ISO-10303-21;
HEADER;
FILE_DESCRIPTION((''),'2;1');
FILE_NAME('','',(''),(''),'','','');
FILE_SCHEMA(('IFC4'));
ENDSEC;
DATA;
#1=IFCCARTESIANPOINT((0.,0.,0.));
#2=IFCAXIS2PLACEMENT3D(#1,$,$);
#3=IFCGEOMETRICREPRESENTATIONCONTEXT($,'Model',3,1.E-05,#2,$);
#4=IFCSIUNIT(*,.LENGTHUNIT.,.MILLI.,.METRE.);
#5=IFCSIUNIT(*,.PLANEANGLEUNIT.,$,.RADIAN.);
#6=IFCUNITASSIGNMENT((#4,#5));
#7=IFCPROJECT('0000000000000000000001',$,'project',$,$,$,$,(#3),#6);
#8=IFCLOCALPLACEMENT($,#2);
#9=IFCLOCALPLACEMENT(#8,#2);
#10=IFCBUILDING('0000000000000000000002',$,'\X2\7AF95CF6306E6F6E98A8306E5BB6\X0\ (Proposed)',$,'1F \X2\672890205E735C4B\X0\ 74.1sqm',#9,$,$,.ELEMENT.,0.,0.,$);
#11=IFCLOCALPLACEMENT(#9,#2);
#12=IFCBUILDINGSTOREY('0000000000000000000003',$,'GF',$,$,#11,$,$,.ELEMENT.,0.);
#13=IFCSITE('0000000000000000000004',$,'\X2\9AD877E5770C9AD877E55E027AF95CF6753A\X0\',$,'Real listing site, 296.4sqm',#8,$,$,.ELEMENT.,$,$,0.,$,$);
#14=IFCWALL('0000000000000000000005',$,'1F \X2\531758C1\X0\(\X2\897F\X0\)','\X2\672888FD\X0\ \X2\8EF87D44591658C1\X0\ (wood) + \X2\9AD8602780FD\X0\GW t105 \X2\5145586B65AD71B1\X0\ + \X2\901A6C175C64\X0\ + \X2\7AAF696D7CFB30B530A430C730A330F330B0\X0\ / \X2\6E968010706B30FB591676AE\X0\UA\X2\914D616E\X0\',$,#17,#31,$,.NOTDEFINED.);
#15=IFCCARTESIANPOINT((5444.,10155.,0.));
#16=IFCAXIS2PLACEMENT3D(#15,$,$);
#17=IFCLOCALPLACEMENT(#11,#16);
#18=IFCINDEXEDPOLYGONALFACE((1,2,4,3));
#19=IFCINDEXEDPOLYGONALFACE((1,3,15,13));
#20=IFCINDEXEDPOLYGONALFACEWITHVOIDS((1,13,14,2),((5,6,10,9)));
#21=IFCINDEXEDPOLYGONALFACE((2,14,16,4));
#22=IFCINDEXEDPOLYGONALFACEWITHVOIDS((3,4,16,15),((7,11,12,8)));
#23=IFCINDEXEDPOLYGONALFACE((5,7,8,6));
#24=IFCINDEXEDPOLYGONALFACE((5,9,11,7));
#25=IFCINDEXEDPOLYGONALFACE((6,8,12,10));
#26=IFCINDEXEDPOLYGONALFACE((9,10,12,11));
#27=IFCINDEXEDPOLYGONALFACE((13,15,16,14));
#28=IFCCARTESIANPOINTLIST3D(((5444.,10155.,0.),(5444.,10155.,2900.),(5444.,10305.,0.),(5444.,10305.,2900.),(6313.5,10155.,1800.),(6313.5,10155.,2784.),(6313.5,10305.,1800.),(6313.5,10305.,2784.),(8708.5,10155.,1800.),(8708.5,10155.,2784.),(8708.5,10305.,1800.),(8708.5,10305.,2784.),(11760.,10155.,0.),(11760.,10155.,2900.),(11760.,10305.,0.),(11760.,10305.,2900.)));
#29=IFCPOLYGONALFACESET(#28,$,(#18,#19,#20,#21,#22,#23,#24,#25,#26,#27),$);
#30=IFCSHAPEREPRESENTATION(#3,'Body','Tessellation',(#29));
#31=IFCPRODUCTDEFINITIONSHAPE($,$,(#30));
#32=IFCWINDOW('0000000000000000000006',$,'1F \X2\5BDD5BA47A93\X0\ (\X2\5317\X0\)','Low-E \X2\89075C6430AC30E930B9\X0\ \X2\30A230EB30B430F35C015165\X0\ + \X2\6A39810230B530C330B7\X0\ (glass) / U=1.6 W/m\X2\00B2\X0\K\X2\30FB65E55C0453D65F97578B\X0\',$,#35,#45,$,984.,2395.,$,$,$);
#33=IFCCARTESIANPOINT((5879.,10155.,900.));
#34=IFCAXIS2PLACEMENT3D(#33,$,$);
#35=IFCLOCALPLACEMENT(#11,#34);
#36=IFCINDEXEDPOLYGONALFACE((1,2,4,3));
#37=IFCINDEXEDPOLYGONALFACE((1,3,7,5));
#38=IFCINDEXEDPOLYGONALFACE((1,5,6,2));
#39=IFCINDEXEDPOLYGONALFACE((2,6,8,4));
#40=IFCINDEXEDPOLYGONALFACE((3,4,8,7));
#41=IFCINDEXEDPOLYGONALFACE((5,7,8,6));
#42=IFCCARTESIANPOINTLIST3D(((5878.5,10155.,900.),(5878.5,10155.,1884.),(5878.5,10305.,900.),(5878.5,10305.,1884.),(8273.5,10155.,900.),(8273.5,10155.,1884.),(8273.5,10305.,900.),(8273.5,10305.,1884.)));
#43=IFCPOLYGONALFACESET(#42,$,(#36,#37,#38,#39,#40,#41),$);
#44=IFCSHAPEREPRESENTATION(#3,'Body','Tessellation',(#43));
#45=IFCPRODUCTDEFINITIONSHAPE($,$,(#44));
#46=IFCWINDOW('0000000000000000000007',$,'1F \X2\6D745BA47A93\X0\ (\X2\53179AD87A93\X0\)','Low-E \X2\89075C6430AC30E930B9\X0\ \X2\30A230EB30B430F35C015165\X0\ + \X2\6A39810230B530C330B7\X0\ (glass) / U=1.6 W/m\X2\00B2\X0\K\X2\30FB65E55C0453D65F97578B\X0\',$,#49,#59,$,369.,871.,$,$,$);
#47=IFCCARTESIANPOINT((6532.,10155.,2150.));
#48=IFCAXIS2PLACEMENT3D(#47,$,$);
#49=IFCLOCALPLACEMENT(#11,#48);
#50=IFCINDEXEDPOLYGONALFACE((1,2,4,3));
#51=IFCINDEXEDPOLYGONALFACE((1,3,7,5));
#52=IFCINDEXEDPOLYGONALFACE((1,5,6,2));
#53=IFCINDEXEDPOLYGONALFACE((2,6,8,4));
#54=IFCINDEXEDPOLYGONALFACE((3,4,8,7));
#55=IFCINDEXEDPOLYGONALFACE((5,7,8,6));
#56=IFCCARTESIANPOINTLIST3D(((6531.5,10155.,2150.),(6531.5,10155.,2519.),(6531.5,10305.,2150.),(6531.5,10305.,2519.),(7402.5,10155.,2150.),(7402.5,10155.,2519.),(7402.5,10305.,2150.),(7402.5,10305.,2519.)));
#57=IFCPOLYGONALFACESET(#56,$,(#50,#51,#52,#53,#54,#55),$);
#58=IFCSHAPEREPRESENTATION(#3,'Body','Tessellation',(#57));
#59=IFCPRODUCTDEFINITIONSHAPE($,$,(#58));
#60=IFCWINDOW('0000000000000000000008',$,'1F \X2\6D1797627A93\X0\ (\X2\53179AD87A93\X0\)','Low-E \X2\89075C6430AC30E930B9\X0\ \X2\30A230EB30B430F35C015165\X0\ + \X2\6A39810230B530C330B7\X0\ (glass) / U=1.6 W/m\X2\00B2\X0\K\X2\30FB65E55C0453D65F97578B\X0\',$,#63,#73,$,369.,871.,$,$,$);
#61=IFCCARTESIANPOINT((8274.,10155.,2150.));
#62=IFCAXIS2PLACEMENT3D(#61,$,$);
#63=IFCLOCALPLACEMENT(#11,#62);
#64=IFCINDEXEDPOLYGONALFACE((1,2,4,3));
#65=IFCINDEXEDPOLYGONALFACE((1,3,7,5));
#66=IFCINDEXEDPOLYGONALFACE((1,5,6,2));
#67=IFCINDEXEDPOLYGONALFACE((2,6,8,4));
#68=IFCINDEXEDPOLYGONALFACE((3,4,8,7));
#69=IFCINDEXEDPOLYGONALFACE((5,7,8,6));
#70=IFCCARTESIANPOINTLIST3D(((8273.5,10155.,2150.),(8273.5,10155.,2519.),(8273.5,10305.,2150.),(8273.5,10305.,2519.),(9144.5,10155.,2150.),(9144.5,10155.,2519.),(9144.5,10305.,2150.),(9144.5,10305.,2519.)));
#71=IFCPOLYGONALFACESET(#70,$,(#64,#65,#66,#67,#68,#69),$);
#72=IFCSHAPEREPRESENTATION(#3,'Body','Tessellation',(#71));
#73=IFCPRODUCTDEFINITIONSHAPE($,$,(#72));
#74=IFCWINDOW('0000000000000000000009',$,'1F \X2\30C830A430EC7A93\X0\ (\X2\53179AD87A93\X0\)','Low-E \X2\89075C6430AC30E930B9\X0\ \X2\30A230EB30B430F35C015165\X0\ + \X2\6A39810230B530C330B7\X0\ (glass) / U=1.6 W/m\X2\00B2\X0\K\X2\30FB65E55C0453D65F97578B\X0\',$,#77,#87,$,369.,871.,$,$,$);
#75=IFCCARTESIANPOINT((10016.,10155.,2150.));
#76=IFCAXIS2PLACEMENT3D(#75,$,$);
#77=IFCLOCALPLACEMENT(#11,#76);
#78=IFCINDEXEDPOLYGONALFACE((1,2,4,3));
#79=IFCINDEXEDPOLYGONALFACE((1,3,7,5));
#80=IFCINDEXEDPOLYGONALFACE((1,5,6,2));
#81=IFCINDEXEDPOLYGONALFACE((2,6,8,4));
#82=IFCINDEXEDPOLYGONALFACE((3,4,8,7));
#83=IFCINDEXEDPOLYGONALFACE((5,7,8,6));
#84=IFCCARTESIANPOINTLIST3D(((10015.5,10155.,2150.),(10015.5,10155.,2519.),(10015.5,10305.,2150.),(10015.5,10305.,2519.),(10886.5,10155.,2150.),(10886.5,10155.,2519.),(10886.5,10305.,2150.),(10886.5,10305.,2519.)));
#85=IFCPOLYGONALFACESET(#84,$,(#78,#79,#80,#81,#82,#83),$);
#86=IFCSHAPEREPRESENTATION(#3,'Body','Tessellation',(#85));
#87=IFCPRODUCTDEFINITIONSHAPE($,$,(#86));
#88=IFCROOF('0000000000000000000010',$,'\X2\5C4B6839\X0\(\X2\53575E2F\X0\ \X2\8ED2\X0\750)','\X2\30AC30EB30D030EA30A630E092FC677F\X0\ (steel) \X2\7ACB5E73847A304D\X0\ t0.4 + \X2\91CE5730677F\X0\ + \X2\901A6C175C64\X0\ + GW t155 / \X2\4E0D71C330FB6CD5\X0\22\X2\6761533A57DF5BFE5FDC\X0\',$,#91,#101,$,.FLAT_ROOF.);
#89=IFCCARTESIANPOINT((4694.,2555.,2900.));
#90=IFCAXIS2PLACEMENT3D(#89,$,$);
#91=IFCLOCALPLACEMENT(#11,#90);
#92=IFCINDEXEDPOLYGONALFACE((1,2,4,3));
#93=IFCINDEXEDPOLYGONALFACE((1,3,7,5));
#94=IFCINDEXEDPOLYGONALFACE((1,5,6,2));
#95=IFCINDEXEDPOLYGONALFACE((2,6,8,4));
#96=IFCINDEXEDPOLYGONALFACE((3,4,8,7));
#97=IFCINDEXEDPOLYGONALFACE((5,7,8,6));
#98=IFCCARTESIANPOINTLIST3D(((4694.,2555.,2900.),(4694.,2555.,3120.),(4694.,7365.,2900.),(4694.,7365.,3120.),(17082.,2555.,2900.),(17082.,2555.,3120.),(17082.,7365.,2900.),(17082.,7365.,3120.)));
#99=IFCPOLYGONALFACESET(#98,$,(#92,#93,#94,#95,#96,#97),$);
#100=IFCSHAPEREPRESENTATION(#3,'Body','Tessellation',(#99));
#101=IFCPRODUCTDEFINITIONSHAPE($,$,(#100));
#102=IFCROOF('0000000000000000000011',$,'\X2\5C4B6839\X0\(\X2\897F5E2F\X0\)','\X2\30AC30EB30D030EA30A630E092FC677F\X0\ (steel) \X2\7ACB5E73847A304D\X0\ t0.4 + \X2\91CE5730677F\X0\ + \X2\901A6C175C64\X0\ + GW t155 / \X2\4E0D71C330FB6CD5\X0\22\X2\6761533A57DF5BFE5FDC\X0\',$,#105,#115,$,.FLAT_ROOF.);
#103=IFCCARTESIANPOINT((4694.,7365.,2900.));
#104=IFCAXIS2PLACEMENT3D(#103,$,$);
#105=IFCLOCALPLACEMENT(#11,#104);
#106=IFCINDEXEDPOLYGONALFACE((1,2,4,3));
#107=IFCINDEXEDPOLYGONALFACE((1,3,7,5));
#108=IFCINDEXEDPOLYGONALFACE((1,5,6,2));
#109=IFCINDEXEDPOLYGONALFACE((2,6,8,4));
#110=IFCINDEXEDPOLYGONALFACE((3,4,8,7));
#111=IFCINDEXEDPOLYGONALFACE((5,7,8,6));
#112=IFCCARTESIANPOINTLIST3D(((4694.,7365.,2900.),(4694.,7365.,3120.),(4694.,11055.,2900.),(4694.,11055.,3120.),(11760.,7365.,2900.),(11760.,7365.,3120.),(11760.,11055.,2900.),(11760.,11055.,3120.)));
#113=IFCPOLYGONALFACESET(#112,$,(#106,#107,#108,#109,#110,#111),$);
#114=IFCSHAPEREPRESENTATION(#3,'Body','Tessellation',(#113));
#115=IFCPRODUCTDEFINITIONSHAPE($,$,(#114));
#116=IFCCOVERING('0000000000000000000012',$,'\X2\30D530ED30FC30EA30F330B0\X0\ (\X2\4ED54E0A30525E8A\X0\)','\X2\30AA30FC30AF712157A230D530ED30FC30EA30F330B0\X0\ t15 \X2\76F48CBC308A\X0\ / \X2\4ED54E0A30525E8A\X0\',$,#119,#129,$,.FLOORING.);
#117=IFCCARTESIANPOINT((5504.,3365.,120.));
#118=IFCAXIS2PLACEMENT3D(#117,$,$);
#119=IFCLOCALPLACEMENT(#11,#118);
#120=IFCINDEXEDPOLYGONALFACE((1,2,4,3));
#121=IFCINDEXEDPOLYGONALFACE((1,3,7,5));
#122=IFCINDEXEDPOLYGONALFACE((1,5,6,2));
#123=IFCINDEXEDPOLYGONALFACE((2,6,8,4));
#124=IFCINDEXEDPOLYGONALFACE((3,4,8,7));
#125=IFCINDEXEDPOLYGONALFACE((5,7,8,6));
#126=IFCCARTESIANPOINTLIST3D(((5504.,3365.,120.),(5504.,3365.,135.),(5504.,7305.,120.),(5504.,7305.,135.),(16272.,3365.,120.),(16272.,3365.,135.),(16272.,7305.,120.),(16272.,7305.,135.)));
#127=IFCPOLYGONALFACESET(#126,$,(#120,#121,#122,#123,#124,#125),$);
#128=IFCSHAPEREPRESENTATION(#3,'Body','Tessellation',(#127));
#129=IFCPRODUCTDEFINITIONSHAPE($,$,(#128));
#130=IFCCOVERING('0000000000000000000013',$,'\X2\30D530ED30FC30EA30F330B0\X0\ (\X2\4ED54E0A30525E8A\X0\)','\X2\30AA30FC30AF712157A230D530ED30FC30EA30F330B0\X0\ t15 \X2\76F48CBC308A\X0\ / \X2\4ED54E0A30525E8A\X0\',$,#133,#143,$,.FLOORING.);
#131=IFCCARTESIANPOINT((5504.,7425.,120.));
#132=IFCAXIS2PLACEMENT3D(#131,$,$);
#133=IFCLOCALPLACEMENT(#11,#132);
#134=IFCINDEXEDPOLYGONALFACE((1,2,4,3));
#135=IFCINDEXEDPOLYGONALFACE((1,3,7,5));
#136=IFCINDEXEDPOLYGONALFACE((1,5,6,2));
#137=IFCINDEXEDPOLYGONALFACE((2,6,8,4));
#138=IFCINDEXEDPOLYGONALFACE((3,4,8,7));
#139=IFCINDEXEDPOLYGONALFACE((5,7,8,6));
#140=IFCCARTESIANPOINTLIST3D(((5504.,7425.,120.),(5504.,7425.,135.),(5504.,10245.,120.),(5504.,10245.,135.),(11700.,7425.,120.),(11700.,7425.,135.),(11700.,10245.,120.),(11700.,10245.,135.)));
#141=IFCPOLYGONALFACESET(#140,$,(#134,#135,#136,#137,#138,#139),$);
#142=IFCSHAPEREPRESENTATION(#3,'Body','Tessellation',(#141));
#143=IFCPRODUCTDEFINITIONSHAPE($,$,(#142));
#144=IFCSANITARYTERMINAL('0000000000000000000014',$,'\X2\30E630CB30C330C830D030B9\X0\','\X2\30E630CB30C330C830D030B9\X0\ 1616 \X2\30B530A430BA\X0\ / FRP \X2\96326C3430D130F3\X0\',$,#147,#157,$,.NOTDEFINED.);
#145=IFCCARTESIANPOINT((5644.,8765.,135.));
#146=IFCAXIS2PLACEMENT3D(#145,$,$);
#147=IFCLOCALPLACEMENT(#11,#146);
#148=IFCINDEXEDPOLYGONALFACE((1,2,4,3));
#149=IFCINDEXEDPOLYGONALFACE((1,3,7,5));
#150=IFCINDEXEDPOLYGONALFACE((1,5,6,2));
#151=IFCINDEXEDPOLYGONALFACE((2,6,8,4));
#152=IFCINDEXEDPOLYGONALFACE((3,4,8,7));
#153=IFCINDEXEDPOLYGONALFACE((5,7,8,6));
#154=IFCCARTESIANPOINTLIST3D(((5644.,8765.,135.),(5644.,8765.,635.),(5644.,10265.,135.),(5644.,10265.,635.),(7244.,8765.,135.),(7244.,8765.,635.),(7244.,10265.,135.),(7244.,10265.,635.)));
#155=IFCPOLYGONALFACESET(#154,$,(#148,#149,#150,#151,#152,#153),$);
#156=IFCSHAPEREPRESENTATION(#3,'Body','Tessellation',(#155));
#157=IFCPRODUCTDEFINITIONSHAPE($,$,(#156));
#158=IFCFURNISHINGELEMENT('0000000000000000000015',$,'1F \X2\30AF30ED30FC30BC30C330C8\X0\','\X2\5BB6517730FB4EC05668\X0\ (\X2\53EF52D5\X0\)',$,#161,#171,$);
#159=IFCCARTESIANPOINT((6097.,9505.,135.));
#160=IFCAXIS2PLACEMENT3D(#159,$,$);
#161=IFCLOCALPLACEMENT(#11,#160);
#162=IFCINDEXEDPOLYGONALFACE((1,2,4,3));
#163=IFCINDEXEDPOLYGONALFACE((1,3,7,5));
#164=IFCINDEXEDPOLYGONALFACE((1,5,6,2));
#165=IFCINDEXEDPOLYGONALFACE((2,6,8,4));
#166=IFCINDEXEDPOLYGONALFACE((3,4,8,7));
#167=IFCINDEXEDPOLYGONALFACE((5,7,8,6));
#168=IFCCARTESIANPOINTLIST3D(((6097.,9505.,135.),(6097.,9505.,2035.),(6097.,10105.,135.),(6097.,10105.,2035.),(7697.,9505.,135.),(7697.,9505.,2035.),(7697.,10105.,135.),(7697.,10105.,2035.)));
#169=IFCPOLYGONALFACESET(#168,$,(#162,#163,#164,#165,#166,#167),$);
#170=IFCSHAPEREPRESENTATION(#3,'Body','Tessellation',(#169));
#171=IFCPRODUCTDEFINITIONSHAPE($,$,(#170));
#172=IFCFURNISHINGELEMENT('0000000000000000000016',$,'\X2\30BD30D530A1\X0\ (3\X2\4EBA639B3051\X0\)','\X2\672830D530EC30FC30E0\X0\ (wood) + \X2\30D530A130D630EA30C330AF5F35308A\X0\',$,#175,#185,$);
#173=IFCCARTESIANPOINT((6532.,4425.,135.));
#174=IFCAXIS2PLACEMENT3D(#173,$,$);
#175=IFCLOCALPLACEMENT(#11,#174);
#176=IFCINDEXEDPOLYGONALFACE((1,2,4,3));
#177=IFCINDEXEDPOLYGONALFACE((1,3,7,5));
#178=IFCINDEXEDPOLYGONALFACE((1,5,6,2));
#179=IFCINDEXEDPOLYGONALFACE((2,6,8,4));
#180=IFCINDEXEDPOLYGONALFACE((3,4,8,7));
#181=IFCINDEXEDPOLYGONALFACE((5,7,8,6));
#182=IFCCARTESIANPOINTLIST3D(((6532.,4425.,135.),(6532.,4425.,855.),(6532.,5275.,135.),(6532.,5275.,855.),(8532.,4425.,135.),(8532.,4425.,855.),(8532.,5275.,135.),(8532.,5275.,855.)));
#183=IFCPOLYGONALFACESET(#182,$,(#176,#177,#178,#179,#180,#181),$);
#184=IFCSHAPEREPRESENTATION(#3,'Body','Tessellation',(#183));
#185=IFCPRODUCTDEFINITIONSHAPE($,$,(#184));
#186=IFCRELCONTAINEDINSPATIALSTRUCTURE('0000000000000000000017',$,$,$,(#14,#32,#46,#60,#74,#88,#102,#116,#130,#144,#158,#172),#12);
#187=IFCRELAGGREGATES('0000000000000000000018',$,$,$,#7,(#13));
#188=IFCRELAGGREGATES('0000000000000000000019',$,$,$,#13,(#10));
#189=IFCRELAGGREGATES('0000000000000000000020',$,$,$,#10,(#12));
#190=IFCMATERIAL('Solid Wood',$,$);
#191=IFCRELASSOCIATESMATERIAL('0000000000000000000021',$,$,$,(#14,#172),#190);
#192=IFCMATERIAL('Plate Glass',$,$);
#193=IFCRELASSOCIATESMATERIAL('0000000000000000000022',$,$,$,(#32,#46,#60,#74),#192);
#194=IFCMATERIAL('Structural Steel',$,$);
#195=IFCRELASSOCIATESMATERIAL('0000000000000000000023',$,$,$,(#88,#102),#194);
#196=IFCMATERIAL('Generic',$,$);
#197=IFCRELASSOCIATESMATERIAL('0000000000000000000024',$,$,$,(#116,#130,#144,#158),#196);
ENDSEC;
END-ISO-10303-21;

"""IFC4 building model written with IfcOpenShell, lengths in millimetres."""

from ifc_helpers import new_model, si_unit, frame, frame_2d, origin, place, context, project, spatial, rectangle, extrude, material, element, fill, save


model = new_model("IFC4")

# Units and contexts
model_context = context("Model", 3, precision=1e-05, world=origin())
ifc_project = project(units=[si_unit("LENGTHUNIT", "METRE", prefix="MILLI"), si_unit("PLANEANGLEUNIT", "RADIAN")], contexts=[model_context])

# Site, building, storey
site_placement = place(None, origin())
site = spatial("IfcSite", under=ifc_project, at=site_placement, Name="高知県高知市竹島町", ObjectType="Real listing site, 296.4sqm", CompositionType="ELEMENT", RefElevation=0.0)
building_placement = place(site_placement, origin())
building = spatial("IfcBuilding", under=site, at=building_placement, Name="竹島の潮風の家 (Proposed)", ObjectType="1F 木造平屋 74.1sqm", CompositionType="ELEMENT", ElevationOfRefHeight=0.0, ElevationOfTerrain=0.0)
storey_placement = place(building_placement, origin())
storey = spatial("IfcBuildingStorey", under=building, at=storey_placement, Name="GF", CompositionType="ELEMENT", Elevation=0.0)

# Shared definitions
ifc_material_1 = material(Name="Solid Wood")

# Shared definitions
ifc_material_2 = material(Name="Plate Glass")

# Wall, openings, windows
wall_1_placement = place(storey_placement, frame((5444.0, 10155.0, 0.0)))
wall_1 = element("IfcWall", 1, at=wall_1_placement, inside=storey, material=ifc_material_1, Name="1F 北壁(西)", Description="木製 軸組外壁 (wood) + 高性能GW t105 充填断熱 + 通気層 + 窯業系サイディング / 準耐火・外皮UA配慮", PredefinedType="NOTDEFINED", context=model_context, shape_type="SweptSolid", body=[
    extrude(rectangle(XDim=6316.0, YDim=150.0, at=frame_2d((3158.0, 75.0))), frame((5444.0, 10155.0, 0.0)), (0.0, 0.0, 1.0), 2900.0),
])
opening_1_placement = place(storey_placement, frame((5879.0, 10155.0, 900.0)))
opening_1 = element("IfcOpeningElement", 2, at=opening_1_placement, cuts=wall_1, PredefinedType="NOTDEFINED", context=model_context, shape_type="SweptSolid", body=[
    extrude(rectangle(XDim=2395.0, YDim=150.0, at=frame_2d((1197.0, 75.0))), frame((5879.0, 10155.0, 900.0)), (0.0, 0.0, 1.0), 984.0),
])
opening_2_placement = place(storey_placement, frame((6532.0, 10155.0, 2150.0)))
opening_2 = element("IfcOpeningElement", 3, at=opening_2_placement, cuts=wall_1, PredefinedType="NOTDEFINED", context=model_context, shape_type="SweptSolid", body=[
    extrude(rectangle(XDim=871.0, YDim=150.0, at=frame_2d((435.0, 75.0))), frame((6532.0, 10155.0, 2150.0)), (0.0, 0.0, 1.0), 369.0),
])
opening_3_placement = place(storey_placement, frame((8274.0, 10155.0, 2150.0)))
opening_3 = element("IfcOpeningElement", 4, at=opening_3_placement, cuts=wall_1, PredefinedType="NOTDEFINED", context=model_context, shape_type="SweptSolid", body=[
    extrude(rectangle(XDim=871.0, YDim=150.0, at=frame_2d((435.0, 75.0))), frame((8274.0, 10155.0, 2150.0)), (0.0, 0.0, 1.0), 369.0),
])
opening_4_placement = place(storey_placement, frame((10016.0, 10155.0, 2150.0)))
opening_4 = element("IfcOpeningElement", 5, at=opening_4_placement, cuts=wall_1, PredefinedType="NOTDEFINED", context=model_context, shape_type="SweptSolid", body=[
    extrude(rectangle(XDim=871.0, YDim=150.0, at=frame_2d((435.0, 75.0))), frame((10016.0, 10155.0, 2150.0)), (0.0, 0.0, 1.0), 369.0),
])
window_1_placement = place(storey_placement, frame((5879.0, 10155.0, 900.0)))
window_1 = element("IfcWindow", 6, at=window_1_placement, inside=storey, material=ifc_material_2, Name="1F 寝室窓 (北)", Description="Low-E 複層ガラス アルゴン封入 + 樹脂サッシ (glass) / U=1.6 W/m²K・日射取得型", OverallHeight=984.0, OverallWidth=2395.0, context=model_context, shape_type="SweptSolid", body=[
    extrude(rectangle(XDim=2395.0, YDim=150.0, at=frame_2d((1197.0, 75.0))), frame((5879.0, 10155.0, 900.0)), (0.0, 0.0, 1.0), 984.0),
])
fill(opening_1, window_1)
window_2_placement = place(storey_placement, frame((6532.0, 10155.0, 2150.0)))
window_2 = element("IfcWindow", 7, at=window_2_placement, inside=storey, material=ifc_material_2, Name="1F 浴室窓 (北高窓)", Description="Low-E 複層ガラス アルゴン封入 + 樹脂サッシ (glass) / U=1.6 W/m²K・日射取得型", OverallHeight=369.0, OverallWidth=871.0, context=model_context, shape_type="SweptSolid", body=[
    extrude(rectangle(XDim=871.0, YDim=150.0, at=frame_2d((435.0, 75.0))), frame((6532.0, 10155.0, 2150.0)), (0.0, 0.0, 1.0), 369.0),
])
fill(opening_2, window_2)
window_3_placement = place(storey_placement, frame((8274.0, 10155.0, 2150.0)))
window_3 = element("IfcWindow", 8, at=window_3_placement, inside=storey, material=ifc_material_2, Name="1F 洗面窓 (北高窓)", Description="Low-E 複層ガラス アルゴン封入 + 樹脂サッシ (glass) / U=1.6 W/m²K・日射取得型", OverallHeight=369.0, OverallWidth=871.0, context=model_context, shape_type="SweptSolid", body=[
    extrude(rectangle(XDim=871.0, YDim=150.0, at=frame_2d((435.0, 75.0))), frame((8274.0, 10155.0, 2150.0)), (0.0, 0.0, 1.0), 369.0),
])
fill(opening_3, window_3)
window_4_placement = place(storey_placement, frame((10016.0, 10155.0, 2150.0)))
window_4 = element("IfcWindow", 9, at=window_4_placement, inside=storey, material=ifc_material_2, Name="1F トイレ窓 (北高窓)", Description="Low-E 複層ガラス アルゴン封入 + 樹脂サッシ (glass) / U=1.6 W/m²K・日射取得型", OverallHeight=369.0, OverallWidth=871.0, context=model_context, shape_type="SweptSolid", body=[
    extrude(rectangle(XDim=871.0, YDim=150.0, at=frame_2d((435.0, 75.0))), frame((10016.0, 10155.0, 2150.0)), (0.0, 0.0, 1.0), 369.0),
])
fill(opening_4, window_4)

# Roofs
ifc_material_3 = material(Name="Structural Steel")
roof_1_placement = place(storey_placement, frame((4694.0, 2555.0, 2900.0)))
element("IfcRoof", 10, at=roof_1_placement, inside=storey, material=ifc_material_3, Name="屋根(南帯 軒750)", Description="ガルバリウム鋼板 (steel) 立平葺き t0.4 + 野地板 + 通気層 + GW t155 / 不燃・法22条区域対応", PredefinedType="FLAT_ROOF", context=model_context, shape_type="SweptSolid", body=[
    extrude(rectangle(XDim=12388.0, YDim=4810.0, at=frame_2d((6194.0, 2405.0))), frame((4694.0, 2555.0, 2900.0)), (0.0, 0.0, 1.0), 220.0),
])
roof_2_placement = place(storey_placement, frame((4694.0, 7365.0, 2900.0)))
element("IfcRoof", 11, at=roof_2_placement, inside=storey, material=ifc_material_3, Name="屋根(西帯)", Description="ガルバリウム鋼板 (steel) 立平葺き t0.4 + 野地板 + 通気層 + GW t155 / 不燃・法22条区域対応", PredefinedType="FLAT_ROOF", context=model_context, shape_type="SweptSolid", body=[
    extrude(rectangle(XDim=7066.0, YDim=3690.0, at=frame_2d((3533.0, 1845.0))), frame((4694.0, 7365.0, 2900.0)), (0.0, 0.0, 1.0), 220.0),
])

# Coverings
ifc_material_4 = material(Name="Generic")
covering_1_placement = place(storey_placement, frame((5504.0, 3365.0, 120.0)))
element("IfcCovering", 12, at=covering_1_placement, inside=storey, material=ifc_material_4, Name="フローリング (仕上げ床)", Description="オーク無垢フローリング t15 直貼り / 仕上げ床", PredefinedType="FLOORING", context=model_context, shape_type="SweptSolid", body=[
    extrude(rectangle(XDim=10768.0, YDim=3940.0, at=frame_2d((5384.0, 1970.0))), frame((5504.0, 3365.0, 120.0)), (0.0, 0.0, 1.0), 15.0),
])
covering_2_placement = place(storey_placement, frame((5504.0, 7425.0, 120.0)))
element("IfcCovering", 13, at=covering_2_placement, inside=storey, material=ifc_material_4, Name="フローリング (仕上げ床)", Description="オーク無垢フローリング t15 直貼り / 仕上げ床", PredefinedType="FLOORING", context=model_context, shape_type="SweptSolid", body=[
    extrude(rectangle(XDim=6196.0, YDim=2820.0, at=frame_2d((3098.0, 1410.0))), frame((5504.0, 7425.0, 120.0)), (0.0, 0.0, 1.0), 15.0),
])

# Sanitary terminal
sanitary_terminal_placement = place(storey_placement, frame((5644.0, 8765.0, 135.0)))
element("IfcSanitaryTerminal", 14, at=sanitary_terminal_placement, inside=storey, material=ifc_material_4, Name="ユニットバス", Description="ユニットバス 1616 サイズ / FRP 防水パン", PredefinedType="NOTDEFINED", context=model_context, shape_type="SweptSolid", body=[
    extrude(rectangle(XDim=1600.0, YDim=1500.0, at=frame_2d((800.0, 750.0))), frame((5644.0, 8765.0, 135.0)), (0.0, 0.0, 1.0), 500.0),
])

# Furnishing elements
furnishing_1_placement = place(storey_placement, frame((6097.0, 9505.0, 135.0)))
element("IfcFurnishingElement", 15, at=furnishing_1_placement, inside=storey, material=ifc_material_4, Name="1F クローゼット", Description="家具・什器 (可動)", context=model_context, shape_type="SweptSolid", body=[
    extrude(rectangle(XDim=1600.0, YDim=600.0, at=frame_2d((800.0, 300.0))), frame((6097.0, 9505.0, 135.0)), (0.0, 0.0, 1.0), 1900.0),
])
furnishing_2_placement = place(storey_placement, frame((6532.0, 4425.0, 135.0)))
element("IfcFurnishingElement", 16, at=furnishing_2_placement, inside=storey, material=ifc_material_1, Name="ソファ (3人掛け)", Description="木フレーム (wood) + ファブリック張り", context=model_context, shape_type="SweptSolid", body=[
    extrude(rectangle(XDim=2000.0, YDim=850.0, at=frame_2d((1000.0, 425.0))), frame((6532.0, 4425.0, 135.0)), (0.0, 0.0, 1.0), 720.0),
])

save(model, "model.ifc")
